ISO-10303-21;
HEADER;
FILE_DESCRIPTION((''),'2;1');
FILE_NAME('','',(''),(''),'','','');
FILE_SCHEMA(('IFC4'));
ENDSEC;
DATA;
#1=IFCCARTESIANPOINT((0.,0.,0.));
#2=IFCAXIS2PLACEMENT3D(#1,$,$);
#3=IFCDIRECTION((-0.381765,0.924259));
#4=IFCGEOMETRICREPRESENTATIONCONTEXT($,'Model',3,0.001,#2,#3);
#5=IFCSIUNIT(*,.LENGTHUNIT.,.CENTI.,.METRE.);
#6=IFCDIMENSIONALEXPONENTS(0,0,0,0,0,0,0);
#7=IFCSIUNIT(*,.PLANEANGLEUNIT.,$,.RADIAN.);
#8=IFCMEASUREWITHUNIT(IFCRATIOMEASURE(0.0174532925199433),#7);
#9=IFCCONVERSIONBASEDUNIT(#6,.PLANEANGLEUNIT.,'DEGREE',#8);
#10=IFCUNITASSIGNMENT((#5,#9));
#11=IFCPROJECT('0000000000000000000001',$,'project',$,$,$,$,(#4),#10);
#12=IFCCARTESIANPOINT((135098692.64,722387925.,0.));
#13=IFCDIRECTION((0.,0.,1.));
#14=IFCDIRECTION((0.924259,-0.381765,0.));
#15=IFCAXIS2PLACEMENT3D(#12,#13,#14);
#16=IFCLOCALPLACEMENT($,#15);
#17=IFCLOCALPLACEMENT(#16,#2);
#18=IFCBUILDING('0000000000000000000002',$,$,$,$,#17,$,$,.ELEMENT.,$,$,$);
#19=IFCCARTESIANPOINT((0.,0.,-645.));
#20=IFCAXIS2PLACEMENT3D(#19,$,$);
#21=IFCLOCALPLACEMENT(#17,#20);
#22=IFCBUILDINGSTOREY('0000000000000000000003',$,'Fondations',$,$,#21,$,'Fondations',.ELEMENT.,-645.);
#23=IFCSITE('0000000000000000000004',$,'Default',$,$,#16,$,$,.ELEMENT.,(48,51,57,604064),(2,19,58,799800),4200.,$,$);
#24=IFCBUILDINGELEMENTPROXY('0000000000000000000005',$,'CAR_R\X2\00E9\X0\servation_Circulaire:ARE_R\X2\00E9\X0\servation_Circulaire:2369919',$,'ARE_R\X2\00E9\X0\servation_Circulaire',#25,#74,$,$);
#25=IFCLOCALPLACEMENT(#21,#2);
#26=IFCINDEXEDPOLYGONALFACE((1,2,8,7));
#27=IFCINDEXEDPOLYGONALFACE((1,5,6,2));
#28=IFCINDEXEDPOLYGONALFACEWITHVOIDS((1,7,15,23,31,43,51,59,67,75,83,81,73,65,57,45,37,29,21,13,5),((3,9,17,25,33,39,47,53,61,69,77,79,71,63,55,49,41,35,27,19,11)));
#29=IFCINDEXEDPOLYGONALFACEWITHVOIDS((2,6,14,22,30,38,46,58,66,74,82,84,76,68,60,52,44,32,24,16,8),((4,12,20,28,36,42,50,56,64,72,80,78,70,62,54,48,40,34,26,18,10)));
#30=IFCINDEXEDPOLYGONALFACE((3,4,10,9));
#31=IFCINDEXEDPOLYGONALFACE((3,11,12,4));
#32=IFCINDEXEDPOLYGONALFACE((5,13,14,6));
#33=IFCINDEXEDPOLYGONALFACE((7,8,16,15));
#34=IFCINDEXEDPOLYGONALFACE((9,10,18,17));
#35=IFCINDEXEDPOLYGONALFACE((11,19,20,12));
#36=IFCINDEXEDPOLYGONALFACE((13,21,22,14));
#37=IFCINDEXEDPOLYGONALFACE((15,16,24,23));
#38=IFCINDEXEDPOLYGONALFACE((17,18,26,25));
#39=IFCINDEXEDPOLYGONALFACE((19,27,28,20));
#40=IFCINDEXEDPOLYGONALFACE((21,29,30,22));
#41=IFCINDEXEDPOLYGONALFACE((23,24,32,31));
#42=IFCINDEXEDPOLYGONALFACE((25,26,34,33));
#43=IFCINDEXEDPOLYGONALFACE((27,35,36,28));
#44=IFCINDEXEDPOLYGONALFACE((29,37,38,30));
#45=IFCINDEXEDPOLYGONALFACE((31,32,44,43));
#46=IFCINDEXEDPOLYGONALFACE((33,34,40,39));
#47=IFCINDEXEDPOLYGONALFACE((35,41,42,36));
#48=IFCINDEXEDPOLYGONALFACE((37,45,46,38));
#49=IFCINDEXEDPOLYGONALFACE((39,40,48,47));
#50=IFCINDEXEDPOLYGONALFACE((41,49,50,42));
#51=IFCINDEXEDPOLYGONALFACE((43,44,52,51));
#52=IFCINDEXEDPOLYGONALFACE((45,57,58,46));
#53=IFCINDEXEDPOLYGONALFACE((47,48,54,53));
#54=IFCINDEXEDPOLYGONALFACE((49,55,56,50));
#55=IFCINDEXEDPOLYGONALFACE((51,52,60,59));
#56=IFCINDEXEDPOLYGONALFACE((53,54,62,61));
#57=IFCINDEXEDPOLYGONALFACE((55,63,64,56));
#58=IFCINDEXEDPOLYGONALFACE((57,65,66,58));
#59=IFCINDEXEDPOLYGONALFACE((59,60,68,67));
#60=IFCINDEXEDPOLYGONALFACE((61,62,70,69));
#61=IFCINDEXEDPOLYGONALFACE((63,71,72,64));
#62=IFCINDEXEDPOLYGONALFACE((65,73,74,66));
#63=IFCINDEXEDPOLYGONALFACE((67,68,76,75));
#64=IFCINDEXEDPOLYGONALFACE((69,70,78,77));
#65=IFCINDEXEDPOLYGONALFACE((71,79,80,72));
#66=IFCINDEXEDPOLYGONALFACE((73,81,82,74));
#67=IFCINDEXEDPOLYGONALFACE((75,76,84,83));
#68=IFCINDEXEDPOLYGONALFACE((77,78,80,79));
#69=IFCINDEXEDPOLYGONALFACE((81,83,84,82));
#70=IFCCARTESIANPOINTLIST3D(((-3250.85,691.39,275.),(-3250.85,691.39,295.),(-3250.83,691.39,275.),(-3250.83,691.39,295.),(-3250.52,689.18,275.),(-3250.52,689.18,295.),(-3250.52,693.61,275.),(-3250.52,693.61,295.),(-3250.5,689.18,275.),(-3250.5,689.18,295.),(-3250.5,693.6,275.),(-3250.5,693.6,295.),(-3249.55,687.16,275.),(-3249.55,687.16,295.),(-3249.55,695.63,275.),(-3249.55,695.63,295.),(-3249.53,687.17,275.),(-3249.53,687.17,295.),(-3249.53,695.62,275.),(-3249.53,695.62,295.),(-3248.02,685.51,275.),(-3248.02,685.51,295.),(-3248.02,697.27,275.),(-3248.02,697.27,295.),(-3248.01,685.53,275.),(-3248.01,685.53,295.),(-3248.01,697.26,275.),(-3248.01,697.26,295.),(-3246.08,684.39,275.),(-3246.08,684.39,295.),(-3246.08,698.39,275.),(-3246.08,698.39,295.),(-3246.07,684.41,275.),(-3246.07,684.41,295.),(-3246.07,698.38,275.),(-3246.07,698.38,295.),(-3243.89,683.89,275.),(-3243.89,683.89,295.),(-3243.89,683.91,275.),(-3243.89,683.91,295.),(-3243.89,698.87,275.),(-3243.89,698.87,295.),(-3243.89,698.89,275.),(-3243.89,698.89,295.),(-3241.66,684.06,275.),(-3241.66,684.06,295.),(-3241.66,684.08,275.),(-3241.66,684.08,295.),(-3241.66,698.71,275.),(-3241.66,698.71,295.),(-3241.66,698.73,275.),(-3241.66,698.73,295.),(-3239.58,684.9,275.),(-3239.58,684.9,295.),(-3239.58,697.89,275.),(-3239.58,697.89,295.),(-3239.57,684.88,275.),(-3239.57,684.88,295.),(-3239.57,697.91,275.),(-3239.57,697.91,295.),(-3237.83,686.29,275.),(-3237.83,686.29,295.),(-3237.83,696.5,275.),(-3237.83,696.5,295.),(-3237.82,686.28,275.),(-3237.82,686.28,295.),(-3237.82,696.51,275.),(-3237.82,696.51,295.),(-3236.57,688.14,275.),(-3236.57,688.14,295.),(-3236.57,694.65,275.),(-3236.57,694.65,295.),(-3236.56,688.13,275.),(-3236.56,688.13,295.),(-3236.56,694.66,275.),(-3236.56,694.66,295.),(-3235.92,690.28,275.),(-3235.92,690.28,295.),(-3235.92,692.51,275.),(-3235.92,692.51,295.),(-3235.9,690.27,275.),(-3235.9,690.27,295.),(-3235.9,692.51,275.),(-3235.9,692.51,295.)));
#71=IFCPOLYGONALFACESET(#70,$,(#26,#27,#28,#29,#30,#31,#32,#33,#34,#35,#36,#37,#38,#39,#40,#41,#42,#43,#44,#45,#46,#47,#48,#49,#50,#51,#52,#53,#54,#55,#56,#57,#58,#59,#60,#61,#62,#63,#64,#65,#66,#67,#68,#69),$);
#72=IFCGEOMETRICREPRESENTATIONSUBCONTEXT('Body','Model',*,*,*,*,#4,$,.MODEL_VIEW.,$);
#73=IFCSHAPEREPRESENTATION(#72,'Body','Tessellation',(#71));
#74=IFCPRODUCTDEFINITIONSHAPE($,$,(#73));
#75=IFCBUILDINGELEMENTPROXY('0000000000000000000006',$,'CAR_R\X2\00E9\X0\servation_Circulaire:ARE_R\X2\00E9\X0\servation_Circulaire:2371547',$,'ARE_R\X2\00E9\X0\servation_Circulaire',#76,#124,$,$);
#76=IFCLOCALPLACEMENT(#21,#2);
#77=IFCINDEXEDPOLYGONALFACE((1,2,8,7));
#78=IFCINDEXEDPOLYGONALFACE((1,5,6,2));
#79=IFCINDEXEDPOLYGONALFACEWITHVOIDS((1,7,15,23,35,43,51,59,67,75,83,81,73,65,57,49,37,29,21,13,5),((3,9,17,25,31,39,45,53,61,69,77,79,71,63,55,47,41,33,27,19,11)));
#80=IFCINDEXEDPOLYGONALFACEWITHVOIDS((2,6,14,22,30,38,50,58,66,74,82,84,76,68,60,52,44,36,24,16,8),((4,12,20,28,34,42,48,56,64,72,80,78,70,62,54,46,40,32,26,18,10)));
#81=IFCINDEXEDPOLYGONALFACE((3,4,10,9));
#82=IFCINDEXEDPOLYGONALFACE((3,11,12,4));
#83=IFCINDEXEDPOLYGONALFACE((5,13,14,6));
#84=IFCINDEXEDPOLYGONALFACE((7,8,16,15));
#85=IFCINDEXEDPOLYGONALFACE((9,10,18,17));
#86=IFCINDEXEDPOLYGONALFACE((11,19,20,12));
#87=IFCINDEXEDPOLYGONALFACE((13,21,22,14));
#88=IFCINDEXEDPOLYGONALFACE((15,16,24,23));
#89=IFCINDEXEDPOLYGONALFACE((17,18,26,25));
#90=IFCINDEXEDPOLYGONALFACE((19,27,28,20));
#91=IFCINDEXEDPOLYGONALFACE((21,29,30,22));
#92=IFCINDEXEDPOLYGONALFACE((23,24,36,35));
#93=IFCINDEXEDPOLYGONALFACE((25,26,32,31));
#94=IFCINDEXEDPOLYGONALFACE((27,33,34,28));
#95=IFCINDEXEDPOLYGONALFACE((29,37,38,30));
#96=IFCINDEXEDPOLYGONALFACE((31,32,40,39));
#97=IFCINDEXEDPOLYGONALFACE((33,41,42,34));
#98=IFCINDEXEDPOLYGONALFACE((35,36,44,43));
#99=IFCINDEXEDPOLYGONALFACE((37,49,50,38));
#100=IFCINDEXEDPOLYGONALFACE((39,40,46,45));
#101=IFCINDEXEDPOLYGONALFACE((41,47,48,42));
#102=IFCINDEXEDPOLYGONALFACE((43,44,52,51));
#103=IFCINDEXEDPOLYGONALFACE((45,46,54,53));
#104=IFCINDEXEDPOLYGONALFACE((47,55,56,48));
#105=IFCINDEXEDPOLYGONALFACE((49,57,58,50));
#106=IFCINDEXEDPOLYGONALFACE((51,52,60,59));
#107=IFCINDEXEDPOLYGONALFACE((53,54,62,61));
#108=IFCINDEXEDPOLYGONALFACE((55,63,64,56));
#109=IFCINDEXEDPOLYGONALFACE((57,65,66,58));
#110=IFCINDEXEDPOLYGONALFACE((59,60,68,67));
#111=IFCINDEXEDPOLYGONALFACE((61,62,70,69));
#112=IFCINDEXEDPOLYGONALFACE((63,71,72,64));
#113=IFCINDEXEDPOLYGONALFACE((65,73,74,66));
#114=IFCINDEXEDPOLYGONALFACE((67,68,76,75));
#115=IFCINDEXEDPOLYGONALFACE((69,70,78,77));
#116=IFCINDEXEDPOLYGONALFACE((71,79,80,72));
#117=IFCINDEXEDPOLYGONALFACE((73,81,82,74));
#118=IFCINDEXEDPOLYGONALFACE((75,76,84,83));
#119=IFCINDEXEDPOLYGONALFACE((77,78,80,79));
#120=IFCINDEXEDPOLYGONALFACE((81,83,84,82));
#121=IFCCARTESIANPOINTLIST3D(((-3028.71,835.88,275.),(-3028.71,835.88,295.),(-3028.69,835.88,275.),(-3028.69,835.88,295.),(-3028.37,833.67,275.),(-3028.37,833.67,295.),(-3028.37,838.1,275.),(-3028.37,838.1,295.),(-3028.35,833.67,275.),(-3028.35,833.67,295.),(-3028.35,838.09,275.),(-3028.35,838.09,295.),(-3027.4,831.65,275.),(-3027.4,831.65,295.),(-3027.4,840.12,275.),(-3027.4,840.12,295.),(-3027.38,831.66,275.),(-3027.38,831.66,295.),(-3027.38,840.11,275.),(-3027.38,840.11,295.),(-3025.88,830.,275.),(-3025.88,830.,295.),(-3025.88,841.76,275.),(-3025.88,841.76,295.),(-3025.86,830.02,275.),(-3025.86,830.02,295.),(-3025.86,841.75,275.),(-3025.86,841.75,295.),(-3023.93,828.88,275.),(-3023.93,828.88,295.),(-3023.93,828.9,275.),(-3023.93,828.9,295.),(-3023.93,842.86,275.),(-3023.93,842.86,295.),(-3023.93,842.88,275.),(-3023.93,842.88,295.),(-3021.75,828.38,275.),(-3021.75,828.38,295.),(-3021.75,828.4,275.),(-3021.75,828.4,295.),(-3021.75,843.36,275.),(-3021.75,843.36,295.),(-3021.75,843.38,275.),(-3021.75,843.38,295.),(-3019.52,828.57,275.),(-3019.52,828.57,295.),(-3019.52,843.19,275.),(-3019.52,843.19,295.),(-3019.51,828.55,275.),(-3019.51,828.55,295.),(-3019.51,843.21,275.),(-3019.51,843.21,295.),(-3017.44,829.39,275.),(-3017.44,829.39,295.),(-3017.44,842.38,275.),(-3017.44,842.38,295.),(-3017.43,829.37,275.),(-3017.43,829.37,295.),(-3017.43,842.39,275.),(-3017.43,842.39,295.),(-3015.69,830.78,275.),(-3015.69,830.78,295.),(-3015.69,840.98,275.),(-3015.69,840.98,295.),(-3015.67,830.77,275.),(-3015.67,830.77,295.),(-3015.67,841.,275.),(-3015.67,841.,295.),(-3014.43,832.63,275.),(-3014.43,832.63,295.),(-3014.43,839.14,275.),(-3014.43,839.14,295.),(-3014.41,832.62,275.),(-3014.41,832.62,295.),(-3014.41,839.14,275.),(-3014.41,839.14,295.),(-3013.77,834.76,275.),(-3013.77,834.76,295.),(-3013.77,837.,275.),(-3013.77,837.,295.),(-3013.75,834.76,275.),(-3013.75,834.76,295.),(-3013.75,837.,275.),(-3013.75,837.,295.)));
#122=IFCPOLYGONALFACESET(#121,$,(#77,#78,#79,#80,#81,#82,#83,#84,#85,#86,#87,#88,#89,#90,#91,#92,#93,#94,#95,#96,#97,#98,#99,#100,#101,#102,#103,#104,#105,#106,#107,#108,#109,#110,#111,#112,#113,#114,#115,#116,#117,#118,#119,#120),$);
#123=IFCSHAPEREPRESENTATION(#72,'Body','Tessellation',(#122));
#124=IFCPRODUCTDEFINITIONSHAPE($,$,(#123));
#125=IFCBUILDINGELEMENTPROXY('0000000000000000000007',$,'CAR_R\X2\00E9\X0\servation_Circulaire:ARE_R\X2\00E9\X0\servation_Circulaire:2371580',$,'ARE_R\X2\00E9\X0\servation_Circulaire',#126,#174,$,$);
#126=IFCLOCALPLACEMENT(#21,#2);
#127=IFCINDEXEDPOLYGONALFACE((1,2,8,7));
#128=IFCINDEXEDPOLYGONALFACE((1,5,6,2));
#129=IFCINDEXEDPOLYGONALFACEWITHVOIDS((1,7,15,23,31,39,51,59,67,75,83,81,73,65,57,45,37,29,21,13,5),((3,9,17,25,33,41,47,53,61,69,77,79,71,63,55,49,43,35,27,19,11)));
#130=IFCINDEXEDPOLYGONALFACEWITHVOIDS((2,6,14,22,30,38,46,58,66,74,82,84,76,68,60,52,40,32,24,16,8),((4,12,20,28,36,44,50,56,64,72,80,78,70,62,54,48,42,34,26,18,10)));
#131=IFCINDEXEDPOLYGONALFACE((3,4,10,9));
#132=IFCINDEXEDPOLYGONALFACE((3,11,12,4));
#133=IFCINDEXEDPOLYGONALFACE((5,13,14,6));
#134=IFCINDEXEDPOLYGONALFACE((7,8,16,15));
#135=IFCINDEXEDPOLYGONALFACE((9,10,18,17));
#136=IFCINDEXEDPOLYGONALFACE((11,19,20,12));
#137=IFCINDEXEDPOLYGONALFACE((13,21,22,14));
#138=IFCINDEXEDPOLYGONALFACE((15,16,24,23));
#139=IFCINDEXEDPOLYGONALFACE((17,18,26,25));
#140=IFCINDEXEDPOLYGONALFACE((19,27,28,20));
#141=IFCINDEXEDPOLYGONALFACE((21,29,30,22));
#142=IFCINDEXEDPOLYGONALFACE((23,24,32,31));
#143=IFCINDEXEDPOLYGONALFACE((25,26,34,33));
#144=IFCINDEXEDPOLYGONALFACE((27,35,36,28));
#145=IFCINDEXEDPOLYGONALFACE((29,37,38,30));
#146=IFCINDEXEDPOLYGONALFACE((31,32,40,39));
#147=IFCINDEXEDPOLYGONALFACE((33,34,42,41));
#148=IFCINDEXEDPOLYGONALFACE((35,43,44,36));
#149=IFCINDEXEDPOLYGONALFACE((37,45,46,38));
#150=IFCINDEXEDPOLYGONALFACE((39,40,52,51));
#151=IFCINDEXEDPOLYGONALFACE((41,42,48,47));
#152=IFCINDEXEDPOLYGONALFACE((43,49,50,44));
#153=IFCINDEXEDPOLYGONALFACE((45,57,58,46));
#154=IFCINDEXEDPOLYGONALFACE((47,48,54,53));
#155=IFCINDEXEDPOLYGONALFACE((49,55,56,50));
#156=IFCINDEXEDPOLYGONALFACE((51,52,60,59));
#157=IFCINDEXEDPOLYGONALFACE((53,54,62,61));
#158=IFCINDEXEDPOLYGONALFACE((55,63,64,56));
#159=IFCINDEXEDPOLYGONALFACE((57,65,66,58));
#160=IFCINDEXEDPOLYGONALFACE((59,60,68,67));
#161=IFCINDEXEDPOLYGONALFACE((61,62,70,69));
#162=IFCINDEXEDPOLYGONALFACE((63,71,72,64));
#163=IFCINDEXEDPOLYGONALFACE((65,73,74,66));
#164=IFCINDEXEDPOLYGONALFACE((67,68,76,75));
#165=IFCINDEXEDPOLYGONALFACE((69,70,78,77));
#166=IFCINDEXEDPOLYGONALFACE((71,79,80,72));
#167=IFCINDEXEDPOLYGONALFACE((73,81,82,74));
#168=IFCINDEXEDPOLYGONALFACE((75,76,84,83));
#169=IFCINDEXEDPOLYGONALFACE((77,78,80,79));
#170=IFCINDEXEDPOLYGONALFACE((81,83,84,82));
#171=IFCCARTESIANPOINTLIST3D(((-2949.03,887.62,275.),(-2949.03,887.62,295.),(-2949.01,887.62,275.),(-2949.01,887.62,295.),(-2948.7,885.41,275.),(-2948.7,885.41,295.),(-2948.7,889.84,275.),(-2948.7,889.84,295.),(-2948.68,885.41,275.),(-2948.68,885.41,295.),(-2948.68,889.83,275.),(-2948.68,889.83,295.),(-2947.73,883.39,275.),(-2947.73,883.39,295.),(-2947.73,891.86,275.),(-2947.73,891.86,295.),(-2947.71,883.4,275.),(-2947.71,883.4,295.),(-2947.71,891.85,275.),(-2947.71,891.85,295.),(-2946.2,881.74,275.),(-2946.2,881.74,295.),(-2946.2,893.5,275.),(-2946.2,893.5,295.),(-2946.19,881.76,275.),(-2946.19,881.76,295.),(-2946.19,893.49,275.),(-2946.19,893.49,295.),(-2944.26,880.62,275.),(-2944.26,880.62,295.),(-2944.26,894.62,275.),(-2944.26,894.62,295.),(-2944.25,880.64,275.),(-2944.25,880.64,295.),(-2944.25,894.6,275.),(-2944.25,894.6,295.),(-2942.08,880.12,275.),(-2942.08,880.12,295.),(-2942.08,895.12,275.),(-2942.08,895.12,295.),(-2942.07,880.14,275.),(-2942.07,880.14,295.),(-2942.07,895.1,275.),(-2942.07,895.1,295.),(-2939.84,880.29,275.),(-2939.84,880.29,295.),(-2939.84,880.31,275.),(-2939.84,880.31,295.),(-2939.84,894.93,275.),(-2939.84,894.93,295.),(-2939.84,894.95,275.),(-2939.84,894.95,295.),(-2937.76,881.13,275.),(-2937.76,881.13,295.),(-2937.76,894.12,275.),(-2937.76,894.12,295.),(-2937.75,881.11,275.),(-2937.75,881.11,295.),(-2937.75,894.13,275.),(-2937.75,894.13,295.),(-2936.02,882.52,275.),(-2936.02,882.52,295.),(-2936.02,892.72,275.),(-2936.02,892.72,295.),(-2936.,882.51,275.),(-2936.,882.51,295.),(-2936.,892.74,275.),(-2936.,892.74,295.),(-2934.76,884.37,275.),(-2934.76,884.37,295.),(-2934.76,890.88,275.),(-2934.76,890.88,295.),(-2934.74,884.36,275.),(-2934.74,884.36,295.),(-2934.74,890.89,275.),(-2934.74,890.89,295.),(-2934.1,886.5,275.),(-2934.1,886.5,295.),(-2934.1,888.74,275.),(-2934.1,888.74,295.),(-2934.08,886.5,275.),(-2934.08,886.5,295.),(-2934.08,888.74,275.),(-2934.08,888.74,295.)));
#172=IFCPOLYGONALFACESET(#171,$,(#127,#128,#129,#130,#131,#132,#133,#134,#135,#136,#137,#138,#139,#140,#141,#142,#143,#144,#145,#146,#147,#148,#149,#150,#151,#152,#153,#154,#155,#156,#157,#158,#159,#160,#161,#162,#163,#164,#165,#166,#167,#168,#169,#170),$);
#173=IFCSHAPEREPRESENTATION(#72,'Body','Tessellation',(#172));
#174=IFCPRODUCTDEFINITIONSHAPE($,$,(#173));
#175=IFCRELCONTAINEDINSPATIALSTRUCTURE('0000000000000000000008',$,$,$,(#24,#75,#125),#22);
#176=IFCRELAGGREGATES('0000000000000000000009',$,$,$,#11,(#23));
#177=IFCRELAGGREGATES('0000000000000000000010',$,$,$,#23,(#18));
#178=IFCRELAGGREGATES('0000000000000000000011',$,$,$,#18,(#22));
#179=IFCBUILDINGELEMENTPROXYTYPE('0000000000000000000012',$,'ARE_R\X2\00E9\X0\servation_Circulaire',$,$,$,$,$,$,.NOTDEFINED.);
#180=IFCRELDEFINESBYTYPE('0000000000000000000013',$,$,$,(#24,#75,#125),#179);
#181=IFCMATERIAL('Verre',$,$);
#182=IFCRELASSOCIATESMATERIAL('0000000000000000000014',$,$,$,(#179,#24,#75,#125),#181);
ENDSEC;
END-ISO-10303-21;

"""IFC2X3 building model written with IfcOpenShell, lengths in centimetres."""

from ifc_helpers import new_model, entity, si_unit, converted_unit, direction, frame, frame_2d, origin, place, context, subcontext, project, spatial, hollow_circle, extrude, source, transform, mapped, material, type_object, type_shapes, element, save


model = new_model("IFC2X3")

# Units and contexts
model_context = context("Model", 3, precision=0.001, world=origin(), true_north=direction((-0.381765, 0.924259)))
body_context = subcontext(model_context, "Body", "Model", "MODEL_VIEW")
ifc_project = project(units=[si_unit("LENGTHUNIT", "METRE", prefix="CENTI"), converted_unit("PLANEANGLEUNIT", "DEGREE", entity("IfcRatioMeasure", 0.0174532925199433), si_unit("PLANEANGLEUNIT", "RADIAN"), dimensions=[0, 0, 0, 0, 0, 0, 0])], contexts=[model_context])

# Site, building, storey
site_placement = place(None, frame((135098692.64, 722387925.0, 0.0), z_axis=(0.0, 0.0, 1.0), x_axis=(0.924259, -0.381765, 0.0)))
site = spatial("IfcSite", under=ifc_project, at=site_placement, Name="Default", CompositionType="ELEMENT", RefLatitude=(48, 51, 57, 604064), RefLongitude=(2, 19, 58, 799800), RefElevation=4200.0)
building_placement = place(site_placement, origin())
building = spatial("IfcBuilding", under=site, at=building_placement, CompositionType="ELEMENT")
storey_placement = place(building_placement, frame((0.0, 0.0, -645.0)))
storey = spatial("IfcBuildingStorey", under=building, at=storey_placement, Name="Fondations", LongName="Fondations", CompositionType="ELEMENT", Elevation=-645.0)

# Building element proxies
ifc_material_1 = material(Name="Verre")
building_element_proxy_type_1 = type_object("IfcBuildingElementProxyType", Name="ARE_Réservation_Circulaire", PredefinedType="NOTDEFINED", material=ifc_material_1)
shared_shape_1 = source(origin(), body_context, "Body", "SweptSolid", [
    extrude(hollow_circle(Radius=7.52, WallThickness=0.02, at=frame_2d((0.0, 0.0), x_axis=(1.0, 0.0))), frame((0.0, 0.0, -20.0)), (0.0, 0.0, 1.0), 20.0),
])
type_shapes(building_element_proxy_type_1, [shared_shape_1])
for number, where, z_axis, x_axis, name in (
    (1, (-3243.33, 691.39, 295.0), (0.0, 0.0, 1.0), (-1.0, 0.0, 0.0), "CAR_Réservation_Circulaire:ARE_Réservation_Circulaire:2369919"),
    (2, (-3021.19, 835.88, 295.0), (0.0, 0.0, 1.0), (-1.0, 0.0, 0.0), "CAR_Réservation_Circulaire:ARE_Réservation_Circulaire:2371547"),
    (3, (-2941.51, 887.62, 295.0), (0.0, 0.0, 1.0), (-1.0, 0.0, 0.0), "CAR_Réservation_Circulaire:ARE_Réservation_Circulaire:2371580"),
):
    element("IfcBuildingElementProxy", number, at=place(storey_placement, frame(where, z_axis=z_axis, x_axis=x_axis)), inside=storey, type_object=building_element_proxy_type_1, material=ifc_material_1, Name=name, ObjectType="ARE_Réservation_Circulaire", context=body_context, shape_type="MappedRepresentation", body=[
        mapped(shared_shape_1, transform((0.0, 0.0, 0.0), scale=1.0)),
    ])

save(model, "model.ifc")
